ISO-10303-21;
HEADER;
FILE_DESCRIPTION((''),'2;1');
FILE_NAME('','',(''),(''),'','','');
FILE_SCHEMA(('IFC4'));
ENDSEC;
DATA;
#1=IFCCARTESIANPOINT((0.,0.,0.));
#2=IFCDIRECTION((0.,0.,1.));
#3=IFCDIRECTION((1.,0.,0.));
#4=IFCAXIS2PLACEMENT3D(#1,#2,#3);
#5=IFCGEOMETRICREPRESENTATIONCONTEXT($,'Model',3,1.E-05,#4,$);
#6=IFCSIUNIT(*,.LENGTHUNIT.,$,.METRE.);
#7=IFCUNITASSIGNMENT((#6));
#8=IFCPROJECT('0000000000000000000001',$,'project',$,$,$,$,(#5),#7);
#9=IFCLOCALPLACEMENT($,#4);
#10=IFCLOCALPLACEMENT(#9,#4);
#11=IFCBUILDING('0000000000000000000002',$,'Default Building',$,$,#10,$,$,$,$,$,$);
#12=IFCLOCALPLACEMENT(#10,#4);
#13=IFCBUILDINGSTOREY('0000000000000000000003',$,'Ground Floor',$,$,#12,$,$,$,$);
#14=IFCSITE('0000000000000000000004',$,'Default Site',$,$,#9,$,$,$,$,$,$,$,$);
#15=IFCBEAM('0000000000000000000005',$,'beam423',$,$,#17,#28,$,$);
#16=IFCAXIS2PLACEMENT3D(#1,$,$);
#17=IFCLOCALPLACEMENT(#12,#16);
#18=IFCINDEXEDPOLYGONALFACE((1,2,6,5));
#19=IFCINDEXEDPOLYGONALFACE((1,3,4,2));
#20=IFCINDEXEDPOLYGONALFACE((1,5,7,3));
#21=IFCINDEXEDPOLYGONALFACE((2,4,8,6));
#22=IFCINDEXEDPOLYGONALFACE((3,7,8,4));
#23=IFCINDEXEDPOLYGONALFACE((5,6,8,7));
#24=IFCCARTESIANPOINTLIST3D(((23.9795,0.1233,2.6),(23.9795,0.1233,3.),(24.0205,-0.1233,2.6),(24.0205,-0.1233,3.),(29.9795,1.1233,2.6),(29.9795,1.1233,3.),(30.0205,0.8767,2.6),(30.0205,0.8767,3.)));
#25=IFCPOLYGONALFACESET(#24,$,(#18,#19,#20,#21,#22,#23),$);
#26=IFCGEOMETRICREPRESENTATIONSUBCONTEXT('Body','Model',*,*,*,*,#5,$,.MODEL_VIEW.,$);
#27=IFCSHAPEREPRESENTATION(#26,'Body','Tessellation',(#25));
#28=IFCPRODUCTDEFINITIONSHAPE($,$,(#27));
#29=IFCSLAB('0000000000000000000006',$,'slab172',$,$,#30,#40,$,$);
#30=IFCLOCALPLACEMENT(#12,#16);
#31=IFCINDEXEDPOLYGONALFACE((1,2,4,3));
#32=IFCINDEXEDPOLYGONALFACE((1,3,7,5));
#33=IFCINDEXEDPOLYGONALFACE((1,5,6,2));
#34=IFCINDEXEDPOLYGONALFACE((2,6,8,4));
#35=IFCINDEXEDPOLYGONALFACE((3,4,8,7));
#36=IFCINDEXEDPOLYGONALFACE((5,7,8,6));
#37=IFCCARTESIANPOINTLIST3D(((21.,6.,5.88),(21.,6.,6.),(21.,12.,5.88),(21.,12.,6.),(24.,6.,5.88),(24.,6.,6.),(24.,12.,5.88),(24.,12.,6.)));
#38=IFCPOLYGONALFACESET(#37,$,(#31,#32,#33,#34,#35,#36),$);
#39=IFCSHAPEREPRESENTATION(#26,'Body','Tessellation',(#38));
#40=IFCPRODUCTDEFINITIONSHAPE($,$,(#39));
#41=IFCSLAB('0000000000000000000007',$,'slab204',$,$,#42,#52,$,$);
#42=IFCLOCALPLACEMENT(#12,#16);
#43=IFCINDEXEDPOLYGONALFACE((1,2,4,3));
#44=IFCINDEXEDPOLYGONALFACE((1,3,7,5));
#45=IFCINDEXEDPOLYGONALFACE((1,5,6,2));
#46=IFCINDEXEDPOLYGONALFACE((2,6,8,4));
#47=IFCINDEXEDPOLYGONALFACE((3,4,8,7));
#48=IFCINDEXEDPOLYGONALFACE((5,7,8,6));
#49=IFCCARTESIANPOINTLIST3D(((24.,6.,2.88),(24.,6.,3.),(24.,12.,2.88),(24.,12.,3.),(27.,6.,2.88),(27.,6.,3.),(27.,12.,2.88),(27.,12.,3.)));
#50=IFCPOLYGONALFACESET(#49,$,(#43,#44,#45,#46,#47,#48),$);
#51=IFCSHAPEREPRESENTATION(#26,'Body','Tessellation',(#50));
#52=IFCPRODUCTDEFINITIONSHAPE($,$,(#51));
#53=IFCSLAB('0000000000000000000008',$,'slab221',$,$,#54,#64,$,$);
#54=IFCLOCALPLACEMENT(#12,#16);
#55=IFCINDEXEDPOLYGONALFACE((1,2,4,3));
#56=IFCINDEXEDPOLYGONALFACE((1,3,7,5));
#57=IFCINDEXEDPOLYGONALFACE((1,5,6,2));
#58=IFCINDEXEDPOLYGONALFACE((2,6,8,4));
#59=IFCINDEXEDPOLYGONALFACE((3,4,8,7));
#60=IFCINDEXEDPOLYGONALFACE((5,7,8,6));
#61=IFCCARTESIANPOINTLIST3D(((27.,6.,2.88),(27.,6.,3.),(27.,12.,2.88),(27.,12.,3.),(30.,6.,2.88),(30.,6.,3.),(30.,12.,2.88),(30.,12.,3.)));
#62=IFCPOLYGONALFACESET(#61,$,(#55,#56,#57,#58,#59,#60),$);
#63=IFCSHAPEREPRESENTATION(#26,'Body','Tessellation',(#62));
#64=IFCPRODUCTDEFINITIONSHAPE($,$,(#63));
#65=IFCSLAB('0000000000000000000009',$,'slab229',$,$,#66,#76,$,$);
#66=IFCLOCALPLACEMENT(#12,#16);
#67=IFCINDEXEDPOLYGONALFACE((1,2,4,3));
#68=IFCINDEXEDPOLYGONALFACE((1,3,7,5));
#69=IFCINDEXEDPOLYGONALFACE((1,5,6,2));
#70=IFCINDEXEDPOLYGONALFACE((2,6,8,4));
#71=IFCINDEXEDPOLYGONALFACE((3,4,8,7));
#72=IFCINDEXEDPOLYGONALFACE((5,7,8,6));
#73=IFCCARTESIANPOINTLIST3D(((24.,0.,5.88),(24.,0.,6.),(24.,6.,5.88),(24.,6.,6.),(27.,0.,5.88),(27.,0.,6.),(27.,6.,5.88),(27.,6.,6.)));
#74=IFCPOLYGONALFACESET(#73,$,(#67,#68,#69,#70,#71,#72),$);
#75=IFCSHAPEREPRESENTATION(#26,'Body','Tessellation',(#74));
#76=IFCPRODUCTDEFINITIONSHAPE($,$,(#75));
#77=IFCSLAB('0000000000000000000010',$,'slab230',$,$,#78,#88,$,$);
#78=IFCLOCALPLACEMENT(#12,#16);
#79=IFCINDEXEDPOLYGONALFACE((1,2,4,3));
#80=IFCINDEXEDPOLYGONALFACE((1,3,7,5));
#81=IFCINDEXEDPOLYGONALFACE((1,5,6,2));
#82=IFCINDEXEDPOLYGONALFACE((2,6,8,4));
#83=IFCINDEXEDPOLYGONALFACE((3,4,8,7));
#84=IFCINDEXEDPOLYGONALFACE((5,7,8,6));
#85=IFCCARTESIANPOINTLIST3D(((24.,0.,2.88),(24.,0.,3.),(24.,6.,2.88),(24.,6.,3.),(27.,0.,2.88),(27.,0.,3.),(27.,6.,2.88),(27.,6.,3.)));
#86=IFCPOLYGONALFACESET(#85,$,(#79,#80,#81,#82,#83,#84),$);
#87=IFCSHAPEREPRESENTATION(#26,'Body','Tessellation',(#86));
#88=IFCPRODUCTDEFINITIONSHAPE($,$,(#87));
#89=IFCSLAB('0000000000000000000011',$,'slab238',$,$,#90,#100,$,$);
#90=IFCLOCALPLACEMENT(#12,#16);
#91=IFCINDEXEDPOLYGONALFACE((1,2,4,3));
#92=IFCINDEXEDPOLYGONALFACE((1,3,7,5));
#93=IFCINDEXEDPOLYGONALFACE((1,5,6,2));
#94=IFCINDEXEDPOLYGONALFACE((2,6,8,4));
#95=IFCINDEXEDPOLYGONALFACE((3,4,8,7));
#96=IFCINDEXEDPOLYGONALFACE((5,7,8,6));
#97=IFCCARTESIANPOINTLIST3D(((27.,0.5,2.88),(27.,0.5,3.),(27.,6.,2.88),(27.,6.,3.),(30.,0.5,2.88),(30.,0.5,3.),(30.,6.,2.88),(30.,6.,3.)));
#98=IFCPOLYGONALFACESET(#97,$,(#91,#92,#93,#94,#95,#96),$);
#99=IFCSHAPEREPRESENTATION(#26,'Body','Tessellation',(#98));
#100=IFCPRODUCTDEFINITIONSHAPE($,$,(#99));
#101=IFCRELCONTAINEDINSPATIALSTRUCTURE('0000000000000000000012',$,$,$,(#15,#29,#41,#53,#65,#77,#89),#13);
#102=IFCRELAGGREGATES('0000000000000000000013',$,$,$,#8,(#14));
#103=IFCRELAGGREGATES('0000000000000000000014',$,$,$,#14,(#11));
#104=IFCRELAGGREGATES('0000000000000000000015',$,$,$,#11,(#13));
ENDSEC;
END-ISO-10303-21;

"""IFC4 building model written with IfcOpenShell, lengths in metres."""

from ifc_helpers import new_model, si_unit, frame, origin_with_axes, place, context, subcontext, project, spatial, indexed_curve, outline, extrude, element, save


model = new_model("IFC4")

# Units and contexts
model_context = context("Model", 3, precision=1e-05, world=origin_with_axes())
body_context = subcontext(model_context, "Body", "Model", "MODEL_VIEW")
ifc_project = project(units=[si_unit("LENGTHUNIT", "METRE")], contexts=[model_context])

# Site, building, storey
site_placement = place(None, origin_with_axes())
site = spatial("IfcSite", under=ifc_project, at=site_placement, Name="Default Site")
building_placement = place(site_placement, origin_with_axes())
building = spatial("IfcBuilding", under=site, at=building_placement, Name="Default Building")
storey_placement = place(building_placement, origin_with_axes())
storey = spatial("IfcBuildingStorey", under=building, at=storey_placement, Name="Ground Floor")

# Beam
for number, where, z_axis, x_axis, name in (
    (1, (24.0205, -0.1233, 2.6), (0.0, 0.0, 1.0), (0.986394, 0.164399, 0.0), "beam423"),
):
    element("IfcBeam", number, at=place(storey_placement, frame(where, z_axis=z_axis, x_axis=x_axis)), inside=storey, Name=name, context=body_context, shape_type="SweptSolid", body=[
        extrude(outline(indexed_curve([(0.0, 0.0), (0.0, 0.25), (6.0828, 0.25), (6.0828, 0.0), (0.0, 0.0)], self_intersect=False)), origin_with_axes(), (0.0, 0.0, 1.0), 0.4),
    ])

# Slabs
for number, where, z_axis, x_axis, name in (
    (2, (21.0, 6.0, 5.88), (0.0, 0.0, 1.0), (1.0, 0.0, 0.0), "slab172"),
    (3, (24.0, 6.0, 2.88), (0.0, 0.0, 1.0), (1.0, 0.0, 0.0), "slab204"),
    (4, (27.0, 6.0, 2.88), (0.0, 0.0, 1.0), (1.0, 0.0, 0.0), "slab221"),
    (5, (24.0, 0.0, 5.88), (0.0, 0.0, 1.0), (1.0, 0.0, 0.0), "slab229"),
    (6, (24.0, 0.0, 2.88), (0.0, 0.0, 1.0), (1.0, 0.0, 0.0), "slab230"),
):
    element("IfcSlab", number, at=place(storey_placement, frame(where, z_axis=z_axis, x_axis=x_axis)), inside=storey, Name=name, context=body_context, shape_type="SweptSolid", body=[
        extrude(outline(indexed_curve([(0.0, 0.0), (0.0, 6.0), (3.0, 6.0), (3.0, 0.0), (0.0, 0.0)], self_intersect=False)), origin_with_axes(), (0.0, 0.0, 1.0), 0.12),
    ])
slab_placement = place(storey_placement, frame((27.0, 0.5, 2.88), z_axis=(0.0, 0.0, 1.0), x_axis=(1.0, 0.0, 0.0)))
element("IfcSlab", 7, at=slab_placement, inside=storey, Name="slab238", context=body_context, shape_type="SweptSolid", body=[
    extrude(outline(indexed_curve([(0.0, 0.0), (0.0, 5.5), (3.0, 5.5), (3.0, 0.0), (0.0, 0.0)], self_intersect=False)), origin_with_axes(), (0.0, 0.0, 1.0), 0.12),
])

save(model, "model.ifc")
